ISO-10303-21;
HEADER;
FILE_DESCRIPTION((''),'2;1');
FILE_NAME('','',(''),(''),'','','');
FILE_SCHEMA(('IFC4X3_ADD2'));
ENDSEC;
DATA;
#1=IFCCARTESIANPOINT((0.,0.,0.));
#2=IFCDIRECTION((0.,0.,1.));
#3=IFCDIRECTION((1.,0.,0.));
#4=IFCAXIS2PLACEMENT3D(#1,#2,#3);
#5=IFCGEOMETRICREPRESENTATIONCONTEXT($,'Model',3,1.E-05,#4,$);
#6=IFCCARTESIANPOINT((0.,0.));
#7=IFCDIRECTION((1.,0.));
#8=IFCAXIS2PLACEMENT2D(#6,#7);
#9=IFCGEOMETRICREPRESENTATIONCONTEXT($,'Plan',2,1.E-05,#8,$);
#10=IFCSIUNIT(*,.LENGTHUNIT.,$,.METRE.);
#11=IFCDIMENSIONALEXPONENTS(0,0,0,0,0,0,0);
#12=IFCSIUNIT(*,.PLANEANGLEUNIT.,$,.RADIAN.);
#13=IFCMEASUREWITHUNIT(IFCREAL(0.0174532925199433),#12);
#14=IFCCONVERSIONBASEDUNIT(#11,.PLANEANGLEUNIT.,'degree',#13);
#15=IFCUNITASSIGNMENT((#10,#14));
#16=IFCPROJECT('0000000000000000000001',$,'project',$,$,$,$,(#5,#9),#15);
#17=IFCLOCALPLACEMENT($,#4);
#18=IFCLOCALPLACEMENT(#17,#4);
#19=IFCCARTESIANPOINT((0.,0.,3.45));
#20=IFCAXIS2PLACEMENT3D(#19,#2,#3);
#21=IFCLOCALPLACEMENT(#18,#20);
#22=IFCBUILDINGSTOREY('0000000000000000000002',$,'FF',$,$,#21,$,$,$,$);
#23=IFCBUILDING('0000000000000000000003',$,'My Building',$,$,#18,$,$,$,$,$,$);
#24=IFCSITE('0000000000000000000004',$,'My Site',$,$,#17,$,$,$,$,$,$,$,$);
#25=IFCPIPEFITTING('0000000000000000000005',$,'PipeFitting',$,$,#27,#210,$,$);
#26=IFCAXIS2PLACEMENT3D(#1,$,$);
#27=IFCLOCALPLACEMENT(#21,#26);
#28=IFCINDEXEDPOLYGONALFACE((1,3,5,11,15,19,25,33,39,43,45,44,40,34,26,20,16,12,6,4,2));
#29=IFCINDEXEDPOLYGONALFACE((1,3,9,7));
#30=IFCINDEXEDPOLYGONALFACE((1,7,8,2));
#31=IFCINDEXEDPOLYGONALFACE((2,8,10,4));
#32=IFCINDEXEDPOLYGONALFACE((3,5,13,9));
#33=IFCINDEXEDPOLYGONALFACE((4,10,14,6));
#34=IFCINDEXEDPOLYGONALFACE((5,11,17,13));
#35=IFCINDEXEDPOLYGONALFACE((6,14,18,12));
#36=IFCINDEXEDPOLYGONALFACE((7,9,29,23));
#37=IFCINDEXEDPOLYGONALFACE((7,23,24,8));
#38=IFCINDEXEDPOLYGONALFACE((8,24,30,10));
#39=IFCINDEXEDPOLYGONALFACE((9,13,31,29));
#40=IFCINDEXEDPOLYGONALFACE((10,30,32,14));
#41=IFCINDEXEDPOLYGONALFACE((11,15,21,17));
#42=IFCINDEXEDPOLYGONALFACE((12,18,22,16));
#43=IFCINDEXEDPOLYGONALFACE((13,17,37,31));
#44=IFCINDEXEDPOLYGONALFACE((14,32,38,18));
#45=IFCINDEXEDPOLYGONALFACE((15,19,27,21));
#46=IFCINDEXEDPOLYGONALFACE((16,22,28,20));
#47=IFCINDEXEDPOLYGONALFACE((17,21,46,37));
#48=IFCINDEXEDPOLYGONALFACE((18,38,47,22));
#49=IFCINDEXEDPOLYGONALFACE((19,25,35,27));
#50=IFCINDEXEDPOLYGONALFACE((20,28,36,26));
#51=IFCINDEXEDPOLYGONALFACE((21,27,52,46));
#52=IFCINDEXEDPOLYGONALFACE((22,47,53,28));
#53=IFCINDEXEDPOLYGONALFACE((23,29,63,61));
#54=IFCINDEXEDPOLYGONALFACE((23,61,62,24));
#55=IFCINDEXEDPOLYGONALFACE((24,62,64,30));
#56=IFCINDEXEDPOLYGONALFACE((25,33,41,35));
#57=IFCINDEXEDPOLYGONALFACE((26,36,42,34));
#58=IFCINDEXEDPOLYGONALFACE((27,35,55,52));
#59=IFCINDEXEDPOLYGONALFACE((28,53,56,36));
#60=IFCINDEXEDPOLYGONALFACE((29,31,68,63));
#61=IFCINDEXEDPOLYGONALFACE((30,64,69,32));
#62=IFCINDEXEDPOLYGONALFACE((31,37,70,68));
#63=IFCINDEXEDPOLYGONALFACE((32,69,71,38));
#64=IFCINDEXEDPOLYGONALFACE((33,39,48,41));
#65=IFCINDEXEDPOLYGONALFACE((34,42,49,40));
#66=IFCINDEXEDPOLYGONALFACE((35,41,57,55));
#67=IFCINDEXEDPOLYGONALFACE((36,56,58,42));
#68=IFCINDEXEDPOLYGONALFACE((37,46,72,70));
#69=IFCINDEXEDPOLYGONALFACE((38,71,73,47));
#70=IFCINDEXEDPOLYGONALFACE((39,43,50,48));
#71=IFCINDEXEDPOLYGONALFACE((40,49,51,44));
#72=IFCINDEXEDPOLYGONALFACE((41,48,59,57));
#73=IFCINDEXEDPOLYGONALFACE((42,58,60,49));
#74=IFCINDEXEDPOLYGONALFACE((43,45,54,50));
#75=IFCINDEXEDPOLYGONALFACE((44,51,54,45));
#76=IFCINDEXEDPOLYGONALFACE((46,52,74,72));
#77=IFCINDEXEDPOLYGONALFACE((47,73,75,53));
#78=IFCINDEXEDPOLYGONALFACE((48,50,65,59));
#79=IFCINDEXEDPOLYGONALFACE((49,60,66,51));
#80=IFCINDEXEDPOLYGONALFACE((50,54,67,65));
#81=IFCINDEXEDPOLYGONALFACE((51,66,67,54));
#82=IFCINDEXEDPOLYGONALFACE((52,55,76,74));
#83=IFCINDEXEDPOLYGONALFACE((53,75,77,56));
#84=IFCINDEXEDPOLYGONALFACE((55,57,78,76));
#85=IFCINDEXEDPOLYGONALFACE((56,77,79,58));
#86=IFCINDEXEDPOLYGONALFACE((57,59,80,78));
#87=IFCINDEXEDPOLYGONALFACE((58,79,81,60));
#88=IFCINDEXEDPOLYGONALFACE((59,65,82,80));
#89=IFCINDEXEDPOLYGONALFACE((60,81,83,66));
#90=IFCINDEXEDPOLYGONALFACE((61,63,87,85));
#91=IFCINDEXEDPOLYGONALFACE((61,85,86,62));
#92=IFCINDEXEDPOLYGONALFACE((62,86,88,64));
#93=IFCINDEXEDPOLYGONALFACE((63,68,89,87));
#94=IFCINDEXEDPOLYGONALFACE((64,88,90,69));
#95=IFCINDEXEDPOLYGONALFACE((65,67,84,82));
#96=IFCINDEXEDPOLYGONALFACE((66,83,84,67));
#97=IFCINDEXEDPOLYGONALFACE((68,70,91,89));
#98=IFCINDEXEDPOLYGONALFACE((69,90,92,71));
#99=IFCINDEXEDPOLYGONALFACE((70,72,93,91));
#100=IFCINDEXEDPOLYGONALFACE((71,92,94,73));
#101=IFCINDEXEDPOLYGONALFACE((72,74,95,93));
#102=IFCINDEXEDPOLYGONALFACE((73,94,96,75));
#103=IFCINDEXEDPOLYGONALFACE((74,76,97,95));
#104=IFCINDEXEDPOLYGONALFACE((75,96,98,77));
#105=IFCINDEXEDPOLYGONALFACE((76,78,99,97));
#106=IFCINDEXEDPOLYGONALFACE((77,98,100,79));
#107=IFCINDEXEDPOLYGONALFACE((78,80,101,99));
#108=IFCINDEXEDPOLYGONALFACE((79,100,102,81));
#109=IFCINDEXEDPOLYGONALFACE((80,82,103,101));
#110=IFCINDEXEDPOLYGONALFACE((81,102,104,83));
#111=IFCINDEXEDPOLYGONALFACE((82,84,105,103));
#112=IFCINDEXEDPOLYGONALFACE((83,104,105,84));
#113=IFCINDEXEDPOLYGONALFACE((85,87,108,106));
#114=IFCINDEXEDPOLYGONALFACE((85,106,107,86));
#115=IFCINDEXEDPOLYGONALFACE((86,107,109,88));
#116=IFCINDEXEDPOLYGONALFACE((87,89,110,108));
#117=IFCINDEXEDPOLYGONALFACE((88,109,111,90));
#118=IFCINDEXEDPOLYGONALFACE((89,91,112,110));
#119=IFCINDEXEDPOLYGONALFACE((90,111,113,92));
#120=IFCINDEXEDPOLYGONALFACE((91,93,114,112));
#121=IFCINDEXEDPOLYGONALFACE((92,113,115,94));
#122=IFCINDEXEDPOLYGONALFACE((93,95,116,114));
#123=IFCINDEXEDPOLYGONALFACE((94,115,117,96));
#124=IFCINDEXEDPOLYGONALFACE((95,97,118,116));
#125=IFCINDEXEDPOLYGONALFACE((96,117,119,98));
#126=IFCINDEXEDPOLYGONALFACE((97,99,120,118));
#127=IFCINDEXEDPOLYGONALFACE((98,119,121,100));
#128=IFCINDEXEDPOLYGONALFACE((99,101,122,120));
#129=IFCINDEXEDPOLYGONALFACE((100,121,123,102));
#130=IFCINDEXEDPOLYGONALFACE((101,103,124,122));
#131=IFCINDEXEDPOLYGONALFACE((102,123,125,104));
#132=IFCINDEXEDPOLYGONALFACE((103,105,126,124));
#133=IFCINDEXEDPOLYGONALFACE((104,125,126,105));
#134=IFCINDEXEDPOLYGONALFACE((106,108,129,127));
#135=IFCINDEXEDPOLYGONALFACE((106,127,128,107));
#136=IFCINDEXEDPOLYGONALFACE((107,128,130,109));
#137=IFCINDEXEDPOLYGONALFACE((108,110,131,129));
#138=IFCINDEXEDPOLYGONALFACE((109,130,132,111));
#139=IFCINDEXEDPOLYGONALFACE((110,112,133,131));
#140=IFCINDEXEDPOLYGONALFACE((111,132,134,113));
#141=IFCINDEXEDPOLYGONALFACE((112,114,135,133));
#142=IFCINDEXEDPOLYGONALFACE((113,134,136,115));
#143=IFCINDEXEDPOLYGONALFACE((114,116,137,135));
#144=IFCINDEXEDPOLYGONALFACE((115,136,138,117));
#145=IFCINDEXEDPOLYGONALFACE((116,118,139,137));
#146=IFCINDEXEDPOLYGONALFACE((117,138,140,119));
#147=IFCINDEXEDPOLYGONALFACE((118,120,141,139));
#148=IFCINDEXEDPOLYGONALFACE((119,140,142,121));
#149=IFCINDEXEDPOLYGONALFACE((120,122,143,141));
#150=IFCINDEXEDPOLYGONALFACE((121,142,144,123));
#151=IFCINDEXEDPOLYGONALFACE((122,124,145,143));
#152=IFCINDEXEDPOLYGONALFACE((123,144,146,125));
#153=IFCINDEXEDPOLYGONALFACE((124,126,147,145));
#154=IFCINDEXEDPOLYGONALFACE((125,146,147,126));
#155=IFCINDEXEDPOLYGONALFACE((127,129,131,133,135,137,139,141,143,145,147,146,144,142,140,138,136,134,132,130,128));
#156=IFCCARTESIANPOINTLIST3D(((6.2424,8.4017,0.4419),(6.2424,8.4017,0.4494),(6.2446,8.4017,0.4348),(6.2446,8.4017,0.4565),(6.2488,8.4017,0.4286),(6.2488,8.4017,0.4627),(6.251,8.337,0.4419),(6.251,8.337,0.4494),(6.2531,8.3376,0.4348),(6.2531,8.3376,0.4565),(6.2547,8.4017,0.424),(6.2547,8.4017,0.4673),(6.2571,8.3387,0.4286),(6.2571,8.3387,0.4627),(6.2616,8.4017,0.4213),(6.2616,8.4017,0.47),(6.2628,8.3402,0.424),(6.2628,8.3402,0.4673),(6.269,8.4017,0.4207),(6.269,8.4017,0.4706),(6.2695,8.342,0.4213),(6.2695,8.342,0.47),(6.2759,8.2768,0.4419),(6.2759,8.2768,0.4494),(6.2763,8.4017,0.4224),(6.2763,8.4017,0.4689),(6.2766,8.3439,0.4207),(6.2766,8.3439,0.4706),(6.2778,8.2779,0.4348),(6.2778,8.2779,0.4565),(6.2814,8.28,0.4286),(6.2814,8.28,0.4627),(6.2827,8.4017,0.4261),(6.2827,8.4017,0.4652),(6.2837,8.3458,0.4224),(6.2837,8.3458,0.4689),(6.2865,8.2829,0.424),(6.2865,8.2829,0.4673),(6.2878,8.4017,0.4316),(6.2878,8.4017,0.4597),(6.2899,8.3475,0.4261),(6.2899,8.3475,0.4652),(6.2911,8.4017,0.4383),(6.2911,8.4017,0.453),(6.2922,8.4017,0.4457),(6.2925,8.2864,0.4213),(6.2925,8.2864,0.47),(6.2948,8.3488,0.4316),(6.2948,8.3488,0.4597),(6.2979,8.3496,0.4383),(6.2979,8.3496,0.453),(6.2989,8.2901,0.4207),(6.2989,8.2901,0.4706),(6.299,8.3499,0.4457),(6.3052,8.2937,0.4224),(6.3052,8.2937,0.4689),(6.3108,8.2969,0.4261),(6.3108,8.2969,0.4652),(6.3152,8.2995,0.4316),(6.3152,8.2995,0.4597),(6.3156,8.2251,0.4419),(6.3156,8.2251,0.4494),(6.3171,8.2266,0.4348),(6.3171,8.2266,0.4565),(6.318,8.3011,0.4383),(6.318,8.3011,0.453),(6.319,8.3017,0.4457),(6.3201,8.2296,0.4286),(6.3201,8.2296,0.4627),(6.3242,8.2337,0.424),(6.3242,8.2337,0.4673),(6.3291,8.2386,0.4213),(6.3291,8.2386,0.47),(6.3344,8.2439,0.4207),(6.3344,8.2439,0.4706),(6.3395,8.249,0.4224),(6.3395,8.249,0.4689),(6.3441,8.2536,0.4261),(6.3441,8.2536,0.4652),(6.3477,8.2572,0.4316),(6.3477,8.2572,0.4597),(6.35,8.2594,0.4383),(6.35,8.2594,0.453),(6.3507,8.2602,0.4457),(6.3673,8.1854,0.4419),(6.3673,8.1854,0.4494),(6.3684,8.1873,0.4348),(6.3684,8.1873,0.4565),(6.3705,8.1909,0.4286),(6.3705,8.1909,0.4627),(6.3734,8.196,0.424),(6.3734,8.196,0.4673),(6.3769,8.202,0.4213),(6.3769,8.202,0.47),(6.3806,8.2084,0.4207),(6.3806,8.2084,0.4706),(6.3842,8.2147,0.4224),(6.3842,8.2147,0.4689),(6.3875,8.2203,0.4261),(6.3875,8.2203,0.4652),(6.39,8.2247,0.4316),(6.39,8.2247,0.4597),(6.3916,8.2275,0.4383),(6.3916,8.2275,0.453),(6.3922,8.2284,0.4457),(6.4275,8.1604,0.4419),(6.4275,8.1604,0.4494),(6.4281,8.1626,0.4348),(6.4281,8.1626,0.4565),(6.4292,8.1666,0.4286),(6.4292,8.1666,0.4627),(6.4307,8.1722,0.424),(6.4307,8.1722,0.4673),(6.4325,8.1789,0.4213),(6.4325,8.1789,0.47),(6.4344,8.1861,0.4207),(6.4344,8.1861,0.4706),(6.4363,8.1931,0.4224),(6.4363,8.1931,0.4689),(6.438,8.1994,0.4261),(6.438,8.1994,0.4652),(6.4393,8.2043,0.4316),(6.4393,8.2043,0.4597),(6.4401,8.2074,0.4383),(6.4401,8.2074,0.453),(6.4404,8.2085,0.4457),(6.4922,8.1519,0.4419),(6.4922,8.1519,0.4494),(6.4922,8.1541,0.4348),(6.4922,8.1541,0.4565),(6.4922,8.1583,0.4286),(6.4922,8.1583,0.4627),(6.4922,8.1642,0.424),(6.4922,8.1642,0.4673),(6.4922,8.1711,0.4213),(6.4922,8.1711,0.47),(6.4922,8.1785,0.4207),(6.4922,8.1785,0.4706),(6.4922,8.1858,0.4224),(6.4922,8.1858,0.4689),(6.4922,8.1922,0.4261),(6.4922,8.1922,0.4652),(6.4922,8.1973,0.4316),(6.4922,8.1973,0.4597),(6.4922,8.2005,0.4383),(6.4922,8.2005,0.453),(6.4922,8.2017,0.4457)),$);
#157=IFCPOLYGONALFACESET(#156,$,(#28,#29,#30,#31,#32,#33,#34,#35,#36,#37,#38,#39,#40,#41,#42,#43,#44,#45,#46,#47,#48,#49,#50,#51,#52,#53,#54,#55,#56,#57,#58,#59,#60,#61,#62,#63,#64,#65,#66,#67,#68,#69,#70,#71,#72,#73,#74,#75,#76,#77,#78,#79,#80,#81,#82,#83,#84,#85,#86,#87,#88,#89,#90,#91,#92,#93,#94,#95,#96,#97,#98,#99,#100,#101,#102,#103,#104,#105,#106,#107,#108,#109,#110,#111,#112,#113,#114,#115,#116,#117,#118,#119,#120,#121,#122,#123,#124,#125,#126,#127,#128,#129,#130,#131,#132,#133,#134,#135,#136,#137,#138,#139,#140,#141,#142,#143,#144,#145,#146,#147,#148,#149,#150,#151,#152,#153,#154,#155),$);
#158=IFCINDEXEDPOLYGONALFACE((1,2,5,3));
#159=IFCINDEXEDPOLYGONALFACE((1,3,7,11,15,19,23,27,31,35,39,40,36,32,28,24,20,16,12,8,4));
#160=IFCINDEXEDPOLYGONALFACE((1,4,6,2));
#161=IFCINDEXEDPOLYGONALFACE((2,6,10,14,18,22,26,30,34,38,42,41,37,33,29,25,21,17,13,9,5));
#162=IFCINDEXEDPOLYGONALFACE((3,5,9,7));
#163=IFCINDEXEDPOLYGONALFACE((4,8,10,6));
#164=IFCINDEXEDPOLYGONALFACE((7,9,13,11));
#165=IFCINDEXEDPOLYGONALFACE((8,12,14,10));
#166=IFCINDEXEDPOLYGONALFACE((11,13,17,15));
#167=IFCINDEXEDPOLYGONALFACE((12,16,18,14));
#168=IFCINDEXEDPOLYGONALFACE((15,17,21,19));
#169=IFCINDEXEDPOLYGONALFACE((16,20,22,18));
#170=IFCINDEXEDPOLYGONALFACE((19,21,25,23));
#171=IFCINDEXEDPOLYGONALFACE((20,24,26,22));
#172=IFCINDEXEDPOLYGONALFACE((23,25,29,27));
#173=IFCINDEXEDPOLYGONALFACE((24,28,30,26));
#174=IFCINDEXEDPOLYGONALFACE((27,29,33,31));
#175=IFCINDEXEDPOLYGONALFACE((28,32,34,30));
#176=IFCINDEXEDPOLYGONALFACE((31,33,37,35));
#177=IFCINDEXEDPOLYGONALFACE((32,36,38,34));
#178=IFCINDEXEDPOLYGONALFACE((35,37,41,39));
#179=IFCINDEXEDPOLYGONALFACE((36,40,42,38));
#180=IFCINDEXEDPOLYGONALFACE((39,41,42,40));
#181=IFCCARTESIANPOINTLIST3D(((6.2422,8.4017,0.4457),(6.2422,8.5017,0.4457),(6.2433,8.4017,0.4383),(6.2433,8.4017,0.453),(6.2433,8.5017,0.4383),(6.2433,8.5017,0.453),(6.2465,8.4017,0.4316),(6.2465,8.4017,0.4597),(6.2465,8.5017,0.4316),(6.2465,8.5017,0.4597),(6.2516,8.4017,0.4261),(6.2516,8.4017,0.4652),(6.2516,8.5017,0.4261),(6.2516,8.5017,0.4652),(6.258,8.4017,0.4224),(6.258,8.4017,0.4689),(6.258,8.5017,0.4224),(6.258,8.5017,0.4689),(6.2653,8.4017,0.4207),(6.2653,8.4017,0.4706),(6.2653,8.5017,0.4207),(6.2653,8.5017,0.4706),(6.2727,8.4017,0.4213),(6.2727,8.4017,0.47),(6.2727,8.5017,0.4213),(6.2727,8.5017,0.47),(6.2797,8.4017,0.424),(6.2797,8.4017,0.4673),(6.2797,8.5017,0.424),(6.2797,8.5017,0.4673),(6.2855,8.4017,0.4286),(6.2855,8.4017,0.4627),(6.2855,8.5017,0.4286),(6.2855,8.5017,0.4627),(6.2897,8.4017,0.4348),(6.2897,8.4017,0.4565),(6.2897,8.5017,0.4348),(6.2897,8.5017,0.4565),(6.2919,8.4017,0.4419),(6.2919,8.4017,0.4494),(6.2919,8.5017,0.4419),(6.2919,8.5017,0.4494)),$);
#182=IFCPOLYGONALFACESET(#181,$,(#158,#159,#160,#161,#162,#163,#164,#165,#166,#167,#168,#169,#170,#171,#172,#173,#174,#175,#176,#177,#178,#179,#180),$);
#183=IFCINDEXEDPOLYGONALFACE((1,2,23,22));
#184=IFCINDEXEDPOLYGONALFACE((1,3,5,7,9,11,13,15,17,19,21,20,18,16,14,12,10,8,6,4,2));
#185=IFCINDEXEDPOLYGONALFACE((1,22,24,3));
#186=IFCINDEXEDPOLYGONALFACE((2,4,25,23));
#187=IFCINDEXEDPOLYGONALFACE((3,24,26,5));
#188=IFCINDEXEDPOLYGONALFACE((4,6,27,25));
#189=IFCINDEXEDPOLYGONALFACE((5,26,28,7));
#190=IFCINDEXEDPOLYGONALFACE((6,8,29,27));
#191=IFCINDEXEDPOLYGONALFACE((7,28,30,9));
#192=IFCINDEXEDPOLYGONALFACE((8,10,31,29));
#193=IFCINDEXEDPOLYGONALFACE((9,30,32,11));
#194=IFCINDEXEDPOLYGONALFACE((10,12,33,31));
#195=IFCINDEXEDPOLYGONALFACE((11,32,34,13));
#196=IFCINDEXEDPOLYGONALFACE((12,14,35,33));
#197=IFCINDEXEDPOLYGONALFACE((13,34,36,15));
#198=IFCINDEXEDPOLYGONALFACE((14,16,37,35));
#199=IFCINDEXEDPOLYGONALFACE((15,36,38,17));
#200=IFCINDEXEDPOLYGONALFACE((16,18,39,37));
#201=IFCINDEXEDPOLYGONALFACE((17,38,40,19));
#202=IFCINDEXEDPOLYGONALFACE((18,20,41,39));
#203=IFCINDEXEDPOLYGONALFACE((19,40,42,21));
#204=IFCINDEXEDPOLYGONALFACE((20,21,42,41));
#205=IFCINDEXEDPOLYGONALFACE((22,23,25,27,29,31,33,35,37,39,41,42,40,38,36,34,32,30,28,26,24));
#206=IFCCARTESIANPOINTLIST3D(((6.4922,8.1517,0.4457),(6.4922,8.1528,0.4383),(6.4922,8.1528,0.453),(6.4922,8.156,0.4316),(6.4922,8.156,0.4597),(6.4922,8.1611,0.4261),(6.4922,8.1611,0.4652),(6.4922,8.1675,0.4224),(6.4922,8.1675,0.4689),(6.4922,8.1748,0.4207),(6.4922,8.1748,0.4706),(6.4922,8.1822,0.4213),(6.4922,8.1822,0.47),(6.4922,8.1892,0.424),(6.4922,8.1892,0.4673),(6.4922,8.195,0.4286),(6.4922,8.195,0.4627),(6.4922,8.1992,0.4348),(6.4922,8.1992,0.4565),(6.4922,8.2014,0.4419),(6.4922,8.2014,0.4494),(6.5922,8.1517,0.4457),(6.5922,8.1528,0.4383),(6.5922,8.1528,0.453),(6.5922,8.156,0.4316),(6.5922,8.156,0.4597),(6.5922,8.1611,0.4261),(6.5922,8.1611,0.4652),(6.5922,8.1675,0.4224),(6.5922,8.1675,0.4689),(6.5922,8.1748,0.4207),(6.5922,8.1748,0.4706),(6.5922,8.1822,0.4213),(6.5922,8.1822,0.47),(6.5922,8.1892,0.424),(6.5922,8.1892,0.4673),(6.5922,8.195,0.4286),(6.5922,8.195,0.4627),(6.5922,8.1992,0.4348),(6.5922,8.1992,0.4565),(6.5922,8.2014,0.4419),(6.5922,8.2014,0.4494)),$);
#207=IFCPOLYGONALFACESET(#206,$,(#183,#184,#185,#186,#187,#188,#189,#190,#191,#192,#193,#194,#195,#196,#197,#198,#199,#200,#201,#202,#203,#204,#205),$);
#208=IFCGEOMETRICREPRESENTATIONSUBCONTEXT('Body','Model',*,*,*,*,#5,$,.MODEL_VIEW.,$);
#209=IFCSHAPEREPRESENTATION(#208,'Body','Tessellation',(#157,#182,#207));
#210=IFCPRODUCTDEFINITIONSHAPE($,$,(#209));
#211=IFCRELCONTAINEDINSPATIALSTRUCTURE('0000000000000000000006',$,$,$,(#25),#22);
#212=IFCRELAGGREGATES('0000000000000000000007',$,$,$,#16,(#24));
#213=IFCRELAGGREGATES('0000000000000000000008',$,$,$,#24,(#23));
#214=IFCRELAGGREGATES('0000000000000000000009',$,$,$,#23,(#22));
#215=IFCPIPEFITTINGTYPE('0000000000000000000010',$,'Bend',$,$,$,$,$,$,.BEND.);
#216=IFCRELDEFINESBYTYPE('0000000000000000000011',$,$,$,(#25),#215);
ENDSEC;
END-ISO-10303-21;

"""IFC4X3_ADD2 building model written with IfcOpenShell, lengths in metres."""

from ifc_helpers import new_model, entity, si_unit, converted_unit, frame, origin_with_axes, origin_2d_with_axis, place, context, subcontext, project, spatial, circle, extrude, source, transform, mapped, type_object, type_shapes, element, save


model = new_model("IFC4X3_ADD2")

# Units and contexts
model_context = context("Model", 3, precision=1e-05, world=origin_with_axes())
plan_context = context("Plan", 2, precision=1e-05, world=origin_2d_with_axis())
body_context = subcontext(model_context, "Body", "Model", "MODEL_VIEW")
ifc_project = project(units=[si_unit("LENGTHUNIT", "METRE"), converted_unit("PLANEANGLEUNIT", "degree", entity("IfcReal", 0.0174532925199433), si_unit("PLANEANGLEUNIT", "RADIAN"), dimensions=[0, 0, 0, 0, 0, 0, 0])], contexts=[model_context, plan_context])

# Site, building, storey
site_placement = place(None, origin_with_axes())
site = spatial("IfcSite", under=ifc_project, at=site_placement, Name="My Site")
building_placement = place(site_placement, origin_with_axes())
building = spatial("IfcBuilding", under=site, at=building_placement, Name="My Building")
storey_placement = place(building_placement, frame((0.0, 0.0, 3.45), z_axis=(0.0, 0.0, 1.0), x_axis=(1.0, 0.0, 0.0)))
storey = spatial("IfcBuildingStorey", under=building, at=storey_placement, Name="FF")

# Pipe fitting
pipe_fitting_type_1 = type_object("IfcPipeFittingType", Name="Bend", PredefinedType="BEND")
shared_shape_1 = source(origin_with_axes(), body_context, "Body", "SolidModel", [
    entity("IfcSweptDiskSolid", entity("IfcIndexedPolyCurve", entity("IfcCartesianPointList3D", [[0.0, 0.0, -0.1], [-0.0659, 0.0, -0.2591], [-0.225, 0.0, -0.325]]), [entity("IfcArcIndex", [1, 2, 3])]), 0.025),
    extrude(circle(Radius=0.025), origin_with_axes(), (0.0, 0.0, -1.0), 0.1),
    extrude(circle(Radius=0.025), frame((-0.225, 0.0, -0.325), z_axis=(-1.0, 0.0, 0.0), x_axis=(0.0, 0.0, -1.0)), (0.0, 0.0, 1.0), 0.1),
])
type_shapes(pipe_fitting_type_1, [shared_shape_1])
pipe_fitting_1_placement = place(storey_placement, frame((6.2672, 8.5017, 0.4457), z_axis=(0.0, 1.0, 0.0), x_axis=(-1.0, 0.0, 0.0)))
element("IfcPipeFitting", 1, at=pipe_fitting_1_placement, inside=storey, type_object=pipe_fitting_type_1, Name="PipeFitting", context=body_context, shape_type="MappedRepresentation", body=[
    mapped(shared_shape_1, transform((0.0, 0.0, 0.0), x_axis=(1.0, 0.0, 0.0), y_axis=(0.0, 1.0, 0.0), z_axis=(0.0, 0.0, 1.0), scale=1.0)),
])

save(model, "model.ifc")
